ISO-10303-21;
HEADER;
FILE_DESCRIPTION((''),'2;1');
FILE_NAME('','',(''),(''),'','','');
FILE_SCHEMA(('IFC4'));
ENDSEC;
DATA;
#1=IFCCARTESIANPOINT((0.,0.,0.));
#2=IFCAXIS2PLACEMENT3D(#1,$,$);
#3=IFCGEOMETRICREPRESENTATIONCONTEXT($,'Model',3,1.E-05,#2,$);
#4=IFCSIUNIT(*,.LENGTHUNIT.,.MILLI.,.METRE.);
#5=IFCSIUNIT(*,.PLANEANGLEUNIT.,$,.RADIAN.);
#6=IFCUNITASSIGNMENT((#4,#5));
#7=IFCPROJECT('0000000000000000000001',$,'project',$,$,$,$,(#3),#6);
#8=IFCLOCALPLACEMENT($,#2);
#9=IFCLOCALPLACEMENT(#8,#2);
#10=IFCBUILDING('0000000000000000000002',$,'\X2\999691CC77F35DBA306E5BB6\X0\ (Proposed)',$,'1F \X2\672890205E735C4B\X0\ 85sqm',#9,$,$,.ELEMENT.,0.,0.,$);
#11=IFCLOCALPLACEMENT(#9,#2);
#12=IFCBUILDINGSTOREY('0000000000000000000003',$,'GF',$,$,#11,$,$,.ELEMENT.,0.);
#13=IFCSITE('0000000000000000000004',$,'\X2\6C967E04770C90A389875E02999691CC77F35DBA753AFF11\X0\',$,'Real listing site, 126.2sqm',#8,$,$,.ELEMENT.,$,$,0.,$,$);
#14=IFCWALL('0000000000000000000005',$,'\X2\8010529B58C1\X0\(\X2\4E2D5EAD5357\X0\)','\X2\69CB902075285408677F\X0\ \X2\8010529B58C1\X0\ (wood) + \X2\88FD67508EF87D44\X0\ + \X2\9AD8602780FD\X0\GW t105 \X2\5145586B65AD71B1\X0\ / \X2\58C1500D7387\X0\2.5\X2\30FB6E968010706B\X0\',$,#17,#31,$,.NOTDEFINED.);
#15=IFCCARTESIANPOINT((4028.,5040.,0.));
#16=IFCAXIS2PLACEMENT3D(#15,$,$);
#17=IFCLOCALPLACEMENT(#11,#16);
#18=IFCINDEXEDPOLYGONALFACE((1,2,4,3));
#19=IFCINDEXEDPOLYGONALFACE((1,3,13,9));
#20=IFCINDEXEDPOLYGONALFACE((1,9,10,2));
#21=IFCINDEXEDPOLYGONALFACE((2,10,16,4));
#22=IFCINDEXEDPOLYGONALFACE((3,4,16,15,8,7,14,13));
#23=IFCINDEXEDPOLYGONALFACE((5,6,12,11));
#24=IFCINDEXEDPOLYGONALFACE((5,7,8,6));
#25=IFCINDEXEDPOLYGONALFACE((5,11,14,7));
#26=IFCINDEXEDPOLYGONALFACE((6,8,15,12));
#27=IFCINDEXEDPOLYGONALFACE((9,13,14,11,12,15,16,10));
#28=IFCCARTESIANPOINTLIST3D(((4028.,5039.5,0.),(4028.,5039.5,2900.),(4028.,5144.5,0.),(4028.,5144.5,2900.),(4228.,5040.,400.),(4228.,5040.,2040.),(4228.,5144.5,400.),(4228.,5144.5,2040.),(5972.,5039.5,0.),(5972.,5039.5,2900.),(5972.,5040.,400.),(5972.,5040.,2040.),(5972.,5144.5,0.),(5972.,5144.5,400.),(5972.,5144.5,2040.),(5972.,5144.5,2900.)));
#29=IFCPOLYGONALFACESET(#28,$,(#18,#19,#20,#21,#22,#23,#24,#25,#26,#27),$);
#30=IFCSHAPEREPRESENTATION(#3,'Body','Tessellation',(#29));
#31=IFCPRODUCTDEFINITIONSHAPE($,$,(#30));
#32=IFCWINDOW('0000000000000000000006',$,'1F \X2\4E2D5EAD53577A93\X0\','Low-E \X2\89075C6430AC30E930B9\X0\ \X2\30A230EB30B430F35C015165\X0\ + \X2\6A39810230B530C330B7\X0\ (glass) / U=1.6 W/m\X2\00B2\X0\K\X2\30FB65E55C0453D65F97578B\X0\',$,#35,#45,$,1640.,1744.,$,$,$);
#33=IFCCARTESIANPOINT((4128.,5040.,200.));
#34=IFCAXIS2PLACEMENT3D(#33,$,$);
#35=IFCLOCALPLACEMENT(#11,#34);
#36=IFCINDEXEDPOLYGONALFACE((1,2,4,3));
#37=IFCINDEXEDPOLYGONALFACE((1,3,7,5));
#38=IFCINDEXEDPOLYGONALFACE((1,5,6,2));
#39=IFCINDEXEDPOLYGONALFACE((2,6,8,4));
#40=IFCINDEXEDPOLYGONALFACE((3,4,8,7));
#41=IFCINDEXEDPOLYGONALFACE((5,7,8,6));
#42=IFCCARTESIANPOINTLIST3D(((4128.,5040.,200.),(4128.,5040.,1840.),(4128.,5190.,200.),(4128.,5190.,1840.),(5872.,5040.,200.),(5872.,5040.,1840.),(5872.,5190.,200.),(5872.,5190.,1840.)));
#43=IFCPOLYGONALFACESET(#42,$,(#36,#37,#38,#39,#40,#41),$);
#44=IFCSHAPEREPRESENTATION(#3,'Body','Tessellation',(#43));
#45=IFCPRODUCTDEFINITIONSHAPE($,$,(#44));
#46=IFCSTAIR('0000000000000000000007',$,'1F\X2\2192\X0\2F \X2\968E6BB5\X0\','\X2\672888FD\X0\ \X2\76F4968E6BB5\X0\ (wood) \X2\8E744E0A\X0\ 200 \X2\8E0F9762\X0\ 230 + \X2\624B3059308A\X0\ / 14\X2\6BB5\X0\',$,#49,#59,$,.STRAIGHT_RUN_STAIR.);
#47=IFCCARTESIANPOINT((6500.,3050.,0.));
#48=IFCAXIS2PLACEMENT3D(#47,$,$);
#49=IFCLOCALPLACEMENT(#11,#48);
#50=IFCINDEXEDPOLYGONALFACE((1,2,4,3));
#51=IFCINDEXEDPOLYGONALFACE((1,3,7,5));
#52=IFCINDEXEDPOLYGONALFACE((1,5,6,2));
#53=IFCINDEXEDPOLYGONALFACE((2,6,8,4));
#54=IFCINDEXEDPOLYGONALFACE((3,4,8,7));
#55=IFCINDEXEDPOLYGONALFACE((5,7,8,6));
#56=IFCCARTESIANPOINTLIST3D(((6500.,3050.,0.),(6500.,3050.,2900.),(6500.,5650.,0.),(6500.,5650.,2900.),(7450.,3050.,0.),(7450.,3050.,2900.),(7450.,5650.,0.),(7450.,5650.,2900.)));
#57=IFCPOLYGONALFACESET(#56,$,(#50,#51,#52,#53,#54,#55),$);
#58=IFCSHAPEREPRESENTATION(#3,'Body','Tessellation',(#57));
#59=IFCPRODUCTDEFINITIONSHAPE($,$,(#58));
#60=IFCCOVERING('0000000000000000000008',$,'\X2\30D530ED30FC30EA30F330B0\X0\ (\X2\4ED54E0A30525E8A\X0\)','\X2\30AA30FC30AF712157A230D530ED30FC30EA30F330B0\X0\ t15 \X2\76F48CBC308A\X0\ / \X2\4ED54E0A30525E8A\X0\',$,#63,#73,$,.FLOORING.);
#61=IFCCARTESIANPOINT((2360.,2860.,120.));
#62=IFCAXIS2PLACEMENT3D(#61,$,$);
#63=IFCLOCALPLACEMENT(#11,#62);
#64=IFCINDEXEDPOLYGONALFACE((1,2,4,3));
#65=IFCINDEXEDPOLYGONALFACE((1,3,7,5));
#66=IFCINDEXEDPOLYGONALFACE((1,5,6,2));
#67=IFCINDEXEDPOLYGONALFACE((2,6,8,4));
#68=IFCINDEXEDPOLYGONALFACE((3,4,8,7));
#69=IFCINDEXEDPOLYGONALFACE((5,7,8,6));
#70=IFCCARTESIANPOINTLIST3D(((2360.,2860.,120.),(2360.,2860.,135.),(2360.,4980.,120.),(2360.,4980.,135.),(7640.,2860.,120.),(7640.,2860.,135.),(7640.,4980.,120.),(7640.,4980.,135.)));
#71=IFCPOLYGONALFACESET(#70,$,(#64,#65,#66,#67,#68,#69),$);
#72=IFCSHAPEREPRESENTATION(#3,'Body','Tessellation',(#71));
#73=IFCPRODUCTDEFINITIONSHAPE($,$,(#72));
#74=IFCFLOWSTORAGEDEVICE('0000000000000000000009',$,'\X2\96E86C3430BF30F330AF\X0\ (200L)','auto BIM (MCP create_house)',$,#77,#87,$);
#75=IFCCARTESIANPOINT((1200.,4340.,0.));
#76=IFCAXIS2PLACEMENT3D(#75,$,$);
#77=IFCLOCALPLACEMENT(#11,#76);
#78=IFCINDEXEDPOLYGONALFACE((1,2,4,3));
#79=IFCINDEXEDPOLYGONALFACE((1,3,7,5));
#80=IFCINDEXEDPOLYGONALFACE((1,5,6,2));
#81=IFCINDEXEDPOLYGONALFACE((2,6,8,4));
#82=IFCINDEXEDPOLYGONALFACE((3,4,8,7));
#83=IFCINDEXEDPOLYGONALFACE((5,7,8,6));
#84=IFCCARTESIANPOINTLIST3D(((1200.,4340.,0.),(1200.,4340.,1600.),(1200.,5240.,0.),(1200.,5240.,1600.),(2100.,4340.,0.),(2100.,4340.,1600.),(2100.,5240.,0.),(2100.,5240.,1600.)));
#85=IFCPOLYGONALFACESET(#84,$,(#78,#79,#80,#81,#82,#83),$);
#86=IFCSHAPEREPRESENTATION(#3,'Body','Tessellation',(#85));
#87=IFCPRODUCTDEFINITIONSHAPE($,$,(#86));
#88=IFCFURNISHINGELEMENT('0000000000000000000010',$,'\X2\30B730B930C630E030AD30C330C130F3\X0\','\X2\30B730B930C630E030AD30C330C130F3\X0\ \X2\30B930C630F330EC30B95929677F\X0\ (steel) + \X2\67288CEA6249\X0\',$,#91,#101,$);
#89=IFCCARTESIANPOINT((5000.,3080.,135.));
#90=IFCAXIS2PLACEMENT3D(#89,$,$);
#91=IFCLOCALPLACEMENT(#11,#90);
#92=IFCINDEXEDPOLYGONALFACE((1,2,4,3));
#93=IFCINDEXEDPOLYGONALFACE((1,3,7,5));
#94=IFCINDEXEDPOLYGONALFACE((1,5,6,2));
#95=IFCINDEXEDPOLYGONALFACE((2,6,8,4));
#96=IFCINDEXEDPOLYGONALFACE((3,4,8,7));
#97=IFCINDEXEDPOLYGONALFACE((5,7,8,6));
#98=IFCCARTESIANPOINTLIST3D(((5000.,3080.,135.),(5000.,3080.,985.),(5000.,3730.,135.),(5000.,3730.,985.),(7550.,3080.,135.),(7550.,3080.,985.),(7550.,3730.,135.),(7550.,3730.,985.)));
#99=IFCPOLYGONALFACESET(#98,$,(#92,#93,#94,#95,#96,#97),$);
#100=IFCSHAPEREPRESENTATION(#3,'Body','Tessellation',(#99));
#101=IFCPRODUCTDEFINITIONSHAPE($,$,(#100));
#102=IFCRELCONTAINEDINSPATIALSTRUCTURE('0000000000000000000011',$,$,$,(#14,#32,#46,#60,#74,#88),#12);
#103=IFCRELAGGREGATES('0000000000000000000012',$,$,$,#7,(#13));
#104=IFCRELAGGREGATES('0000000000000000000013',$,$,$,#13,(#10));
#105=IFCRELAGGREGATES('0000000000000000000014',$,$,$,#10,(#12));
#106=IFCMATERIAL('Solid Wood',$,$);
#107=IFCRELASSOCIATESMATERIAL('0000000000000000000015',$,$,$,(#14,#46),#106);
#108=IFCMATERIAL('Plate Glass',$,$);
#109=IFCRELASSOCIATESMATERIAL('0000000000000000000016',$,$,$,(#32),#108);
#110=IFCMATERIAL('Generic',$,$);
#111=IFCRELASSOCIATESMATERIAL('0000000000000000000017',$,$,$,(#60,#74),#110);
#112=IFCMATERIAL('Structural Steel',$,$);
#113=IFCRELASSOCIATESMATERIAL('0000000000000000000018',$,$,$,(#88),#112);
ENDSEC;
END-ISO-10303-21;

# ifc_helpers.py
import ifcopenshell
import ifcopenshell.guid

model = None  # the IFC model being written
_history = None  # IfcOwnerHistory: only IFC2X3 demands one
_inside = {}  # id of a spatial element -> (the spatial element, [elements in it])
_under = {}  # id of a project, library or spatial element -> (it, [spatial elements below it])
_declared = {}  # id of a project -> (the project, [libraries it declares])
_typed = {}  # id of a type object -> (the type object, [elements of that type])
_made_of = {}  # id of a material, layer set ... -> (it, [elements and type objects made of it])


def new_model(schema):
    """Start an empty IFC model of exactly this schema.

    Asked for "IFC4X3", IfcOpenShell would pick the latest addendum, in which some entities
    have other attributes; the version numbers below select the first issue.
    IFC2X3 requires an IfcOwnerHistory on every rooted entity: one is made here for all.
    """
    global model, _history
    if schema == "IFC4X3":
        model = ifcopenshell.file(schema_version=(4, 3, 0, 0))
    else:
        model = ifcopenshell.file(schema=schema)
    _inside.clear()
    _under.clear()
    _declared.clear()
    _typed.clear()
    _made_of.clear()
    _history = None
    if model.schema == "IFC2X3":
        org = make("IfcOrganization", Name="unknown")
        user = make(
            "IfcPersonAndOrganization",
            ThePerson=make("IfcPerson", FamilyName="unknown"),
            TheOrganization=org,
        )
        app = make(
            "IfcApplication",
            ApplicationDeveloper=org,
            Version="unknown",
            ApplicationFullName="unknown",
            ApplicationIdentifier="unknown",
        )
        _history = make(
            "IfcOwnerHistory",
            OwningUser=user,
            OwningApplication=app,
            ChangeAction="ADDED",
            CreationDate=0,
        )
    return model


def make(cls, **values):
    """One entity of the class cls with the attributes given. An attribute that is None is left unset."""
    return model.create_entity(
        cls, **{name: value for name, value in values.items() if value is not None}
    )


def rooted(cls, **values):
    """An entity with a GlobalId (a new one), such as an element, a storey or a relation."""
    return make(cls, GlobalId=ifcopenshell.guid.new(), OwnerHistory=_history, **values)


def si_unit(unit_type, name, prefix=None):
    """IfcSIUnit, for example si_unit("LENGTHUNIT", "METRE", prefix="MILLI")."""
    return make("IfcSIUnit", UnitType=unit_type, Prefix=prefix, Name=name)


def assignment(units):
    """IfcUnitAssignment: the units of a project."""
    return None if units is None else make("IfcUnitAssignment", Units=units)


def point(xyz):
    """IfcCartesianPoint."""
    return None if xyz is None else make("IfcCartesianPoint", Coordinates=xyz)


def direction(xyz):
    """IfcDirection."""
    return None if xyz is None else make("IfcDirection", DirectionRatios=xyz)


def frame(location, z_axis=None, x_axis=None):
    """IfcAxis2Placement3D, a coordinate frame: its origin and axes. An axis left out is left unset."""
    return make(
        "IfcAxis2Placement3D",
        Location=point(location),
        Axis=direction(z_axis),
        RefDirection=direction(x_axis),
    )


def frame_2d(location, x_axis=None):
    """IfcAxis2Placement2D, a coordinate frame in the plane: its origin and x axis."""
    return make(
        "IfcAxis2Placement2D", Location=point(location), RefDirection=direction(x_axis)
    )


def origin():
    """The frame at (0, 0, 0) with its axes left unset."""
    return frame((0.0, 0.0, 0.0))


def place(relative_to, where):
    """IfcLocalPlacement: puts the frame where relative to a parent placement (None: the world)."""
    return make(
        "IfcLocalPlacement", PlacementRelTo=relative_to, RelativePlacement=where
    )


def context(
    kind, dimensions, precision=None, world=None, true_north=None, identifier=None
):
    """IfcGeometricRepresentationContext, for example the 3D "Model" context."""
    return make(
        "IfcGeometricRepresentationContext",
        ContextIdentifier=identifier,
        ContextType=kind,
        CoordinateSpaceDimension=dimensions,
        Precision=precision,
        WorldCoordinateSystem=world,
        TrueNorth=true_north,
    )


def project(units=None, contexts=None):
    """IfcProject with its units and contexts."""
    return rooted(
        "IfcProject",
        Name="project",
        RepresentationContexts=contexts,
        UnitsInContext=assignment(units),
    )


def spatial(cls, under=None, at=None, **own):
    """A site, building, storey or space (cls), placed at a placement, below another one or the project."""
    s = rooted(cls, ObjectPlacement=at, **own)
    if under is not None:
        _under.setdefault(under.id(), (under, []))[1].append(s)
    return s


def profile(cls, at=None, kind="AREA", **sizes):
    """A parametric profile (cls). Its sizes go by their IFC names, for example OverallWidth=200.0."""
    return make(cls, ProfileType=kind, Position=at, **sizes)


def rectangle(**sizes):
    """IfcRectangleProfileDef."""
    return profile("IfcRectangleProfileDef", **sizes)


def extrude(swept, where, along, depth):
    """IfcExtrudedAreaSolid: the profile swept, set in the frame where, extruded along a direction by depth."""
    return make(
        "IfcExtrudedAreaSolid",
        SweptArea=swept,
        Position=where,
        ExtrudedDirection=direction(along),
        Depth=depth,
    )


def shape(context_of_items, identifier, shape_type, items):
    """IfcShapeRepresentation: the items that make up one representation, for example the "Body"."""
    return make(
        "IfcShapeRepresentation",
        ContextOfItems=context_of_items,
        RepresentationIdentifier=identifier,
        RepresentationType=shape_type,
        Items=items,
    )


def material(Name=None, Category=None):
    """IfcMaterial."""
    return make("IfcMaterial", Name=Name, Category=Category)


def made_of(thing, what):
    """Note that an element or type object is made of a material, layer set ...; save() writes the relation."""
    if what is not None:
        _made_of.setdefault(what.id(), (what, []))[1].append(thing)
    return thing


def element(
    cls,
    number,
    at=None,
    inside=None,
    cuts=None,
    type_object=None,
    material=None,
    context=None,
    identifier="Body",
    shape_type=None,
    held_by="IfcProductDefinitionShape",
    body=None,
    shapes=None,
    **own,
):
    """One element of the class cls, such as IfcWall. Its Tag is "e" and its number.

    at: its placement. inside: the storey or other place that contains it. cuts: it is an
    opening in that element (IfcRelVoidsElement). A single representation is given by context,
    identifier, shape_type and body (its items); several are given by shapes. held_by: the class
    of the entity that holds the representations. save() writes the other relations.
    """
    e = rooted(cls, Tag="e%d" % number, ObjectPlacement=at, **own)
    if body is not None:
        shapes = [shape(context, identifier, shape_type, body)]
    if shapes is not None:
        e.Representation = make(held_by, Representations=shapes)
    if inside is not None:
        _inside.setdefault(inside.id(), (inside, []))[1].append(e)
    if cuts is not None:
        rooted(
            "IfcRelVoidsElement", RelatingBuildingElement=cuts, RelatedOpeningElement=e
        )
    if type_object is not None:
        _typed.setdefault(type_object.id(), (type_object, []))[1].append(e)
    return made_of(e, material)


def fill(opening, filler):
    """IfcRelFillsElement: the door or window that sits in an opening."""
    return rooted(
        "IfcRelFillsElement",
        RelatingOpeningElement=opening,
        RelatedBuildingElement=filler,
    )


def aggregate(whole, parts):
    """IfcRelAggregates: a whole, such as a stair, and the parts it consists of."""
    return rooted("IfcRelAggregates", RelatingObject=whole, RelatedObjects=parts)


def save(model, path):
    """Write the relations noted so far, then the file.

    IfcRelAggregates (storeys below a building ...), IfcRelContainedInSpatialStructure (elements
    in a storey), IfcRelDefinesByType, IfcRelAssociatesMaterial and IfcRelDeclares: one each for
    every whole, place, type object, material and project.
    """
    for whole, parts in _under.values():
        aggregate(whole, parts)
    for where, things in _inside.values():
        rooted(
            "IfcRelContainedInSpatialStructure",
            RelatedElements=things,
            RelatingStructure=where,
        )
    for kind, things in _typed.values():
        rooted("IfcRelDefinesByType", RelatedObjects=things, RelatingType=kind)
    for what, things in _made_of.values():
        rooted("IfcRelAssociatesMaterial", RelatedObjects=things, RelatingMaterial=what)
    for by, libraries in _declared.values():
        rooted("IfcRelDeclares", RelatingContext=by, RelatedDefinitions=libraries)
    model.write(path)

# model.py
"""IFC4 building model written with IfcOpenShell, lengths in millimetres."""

from ifc_helpers import new_model, si_unit, frame, frame_2d, origin, place, context, project, spatial, rectangle, extrude, material, element, fill, save


model = new_model("IFC4")

# Units and contexts
model_context = context("Model", 3, precision=1e-05, world=origin())
ifc_project = project(units=[si_unit("LENGTHUNIT", "METRE", prefix="MILLI"), si_unit("PLANEANGLEUNIT", "RADIAN")], contexts=[model_context])

# Site, building, storey
site_placement = place(None, origin())
site = spatial("IfcSite", under=ifc_project, at=site_placement, Name="沖縄県那覇市首里石嶺町１", ObjectType="Real listing site, 126.2sqm", CompositionType="ELEMENT", RefElevation=0.0)
building_placement = place(site_placement, origin())
building = spatial("IfcBuilding", under=site, at=building_placement, Name="首里石嶺の家 (Proposed)", ObjectType="1F 木造平屋 85sqm", CompositionType="ELEMENT", ElevationOfRefHeight=0.0, ElevationOfTerrain=0.0)
storey_placement = place(building_placement, origin())
storey = spatial("IfcBuildingStorey", under=building, at=storey_placement, Name="GF", CompositionType="ELEMENT", Elevation=0.0)

# Shared definitions
ifc_material_1 = material(Name="Solid Wood")
ifc_material_2 = material(Name="Generic")

# Shared definitions
ifc_material_3 = material(Name="Plate Glass")

# Wall, opening, window
wall_1_placement = place(storey_placement, frame((4028.0, 5040.0, 0.0)))
wall_1 = element("IfcWall", 1, at=wall_1_placement, inside=storey, material=ifc_material_1, Name="耐力壁(中庭南)", Description="構造用合板 耐力壁 (wood) + 製材軸組 + 高性能GW t105 充填断熱 / 壁倍率2.5・準耐火", PredefinedType="NOTDEFINED", context=model_context, shape_type="SweptSolid", body=[
    extrude(rectangle(XDim=1944.0, YDim=105.0, at=frame_2d((972.0, 52.0))), frame((4028.0, 5040.0, 0.0)), (0.0, 0.0, 1.0), 2900.0),
])
opening_1_placement = place(storey_placement, frame((4128.0, 5040.0, 200.0)))
opening_1 = element("IfcOpeningElement", 2, at=opening_1_placement, cuts=wall_1, PredefinedType="NOTDEFINED", context=model_context, shape_type="SweptSolid", body=[
    extrude(rectangle(XDim=1744.0, YDim=150.0, at=frame_2d((872.0, 75.0))), frame((4128.0, 5040.0, 200.0)), (0.0, 0.0, 1.0), 1640.0),
])
window_1_placement = place(storey_placement, frame((4128.0, 5040.0, 200.0)))
window_1 = element("IfcWindow", 3, at=window_1_placement, inside=storey, material=ifc_material_3, Name="1F 中庭南窓", Description="Low-E 複層ガラス アルゴン封入 + 樹脂サッシ (glass) / U=1.6 W/m²K・日射取得型", OverallHeight=1640.0, OverallWidth=1744.0, context=model_context, shape_type="SweptSolid", body=[
    extrude(rectangle(XDim=1744.0, YDim=150.0, at=frame_2d((872.0, 75.0))), frame((4128.0, 5040.0, 200.0)), (0.0, 0.0, 1.0), 1640.0),
])
fill(opening_1, window_1)

# Stair
stair_placement = place(storey_placement, frame((6500.0, 3050.0, 0.0)))
element("IfcStair", 4, at=stair_placement, inside=storey, material=ifc_material_1, Name="1F→2F 階段", Description="木製 直階段 (wood) 蹴上 200 踏面 230 + 手すり / 14段", PredefinedType="STRAIGHT_RUN_STAIR", context=model_context, shape_type="SweptSolid", body=[
    extrude(rectangle(XDim=950.0, YDim=2600.0, at=frame_2d((475.0, 1300.0))), frame((6500.0, 3050.0, 0.0)), (0.0, 0.0, 1.0), 2900.0),
])

# Covering
covering_placement = place(storey_placement, frame((2360.0, 2860.0, 120.0)))
element("IfcCovering", 5, at=covering_placement, inside=storey, material=ifc_material_2, Name="フローリング (仕上げ床)", Description="オーク無垢フローリング t15 直貼り / 仕上げ床", PredefinedType="FLOORING", context=model_context, shape_type="SweptSolid", body=[
    extrude(rectangle(XDim=5280.0, YDim=2120.0, at=frame_2d((2640.0, 1060.0))), frame((2360.0, 2860.0, 120.0)), (0.0, 0.0, 1.0), 15.0),
])

# Flow storage device
flow_storage_device_placement = place(storey_placement, frame((1200.0, 4340.0, 0.0)))
element("IfcFlowStorageDevice", 6, at=flow_storage_device_placement, inside=storey, material=ifc_material_2, Name="雨水タンク (200L)", Description="auto BIM (MCP create_house)", context=model_context, shape_type="SweptSolid", body=[
    extrude(rectangle(XDim=900.0, YDim=900.0, at=frame_2d((450.0, 450.0))), frame((1200.0, 4340.0, 0.0)), (0.0, 0.0, 1.0), 1600.0),
])

# Furnishing element
ifc_material_4 = material(Name="Structural Steel")
furnishing_placement = place(storey_placement, frame((5000.0, 3080.0, 135.0)))
element("IfcFurnishingElement", 7, at=furnishing_placement, inside=storey, material=ifc_material_4, Name="システムキッチン", Description="システムキッチン ステンレス天板 (steel) + 木質扉", context=model_context, shape_type="SweptSolid", body=[
    extrude(rectangle(XDim=2550.0, YDim=650.0, at=frame_2d((1275.0, 325.0))), frame((5000.0, 3080.0, 135.0)), (0.0, 0.0, 1.0), 850.0),
])

save(model, "model.ifc")
